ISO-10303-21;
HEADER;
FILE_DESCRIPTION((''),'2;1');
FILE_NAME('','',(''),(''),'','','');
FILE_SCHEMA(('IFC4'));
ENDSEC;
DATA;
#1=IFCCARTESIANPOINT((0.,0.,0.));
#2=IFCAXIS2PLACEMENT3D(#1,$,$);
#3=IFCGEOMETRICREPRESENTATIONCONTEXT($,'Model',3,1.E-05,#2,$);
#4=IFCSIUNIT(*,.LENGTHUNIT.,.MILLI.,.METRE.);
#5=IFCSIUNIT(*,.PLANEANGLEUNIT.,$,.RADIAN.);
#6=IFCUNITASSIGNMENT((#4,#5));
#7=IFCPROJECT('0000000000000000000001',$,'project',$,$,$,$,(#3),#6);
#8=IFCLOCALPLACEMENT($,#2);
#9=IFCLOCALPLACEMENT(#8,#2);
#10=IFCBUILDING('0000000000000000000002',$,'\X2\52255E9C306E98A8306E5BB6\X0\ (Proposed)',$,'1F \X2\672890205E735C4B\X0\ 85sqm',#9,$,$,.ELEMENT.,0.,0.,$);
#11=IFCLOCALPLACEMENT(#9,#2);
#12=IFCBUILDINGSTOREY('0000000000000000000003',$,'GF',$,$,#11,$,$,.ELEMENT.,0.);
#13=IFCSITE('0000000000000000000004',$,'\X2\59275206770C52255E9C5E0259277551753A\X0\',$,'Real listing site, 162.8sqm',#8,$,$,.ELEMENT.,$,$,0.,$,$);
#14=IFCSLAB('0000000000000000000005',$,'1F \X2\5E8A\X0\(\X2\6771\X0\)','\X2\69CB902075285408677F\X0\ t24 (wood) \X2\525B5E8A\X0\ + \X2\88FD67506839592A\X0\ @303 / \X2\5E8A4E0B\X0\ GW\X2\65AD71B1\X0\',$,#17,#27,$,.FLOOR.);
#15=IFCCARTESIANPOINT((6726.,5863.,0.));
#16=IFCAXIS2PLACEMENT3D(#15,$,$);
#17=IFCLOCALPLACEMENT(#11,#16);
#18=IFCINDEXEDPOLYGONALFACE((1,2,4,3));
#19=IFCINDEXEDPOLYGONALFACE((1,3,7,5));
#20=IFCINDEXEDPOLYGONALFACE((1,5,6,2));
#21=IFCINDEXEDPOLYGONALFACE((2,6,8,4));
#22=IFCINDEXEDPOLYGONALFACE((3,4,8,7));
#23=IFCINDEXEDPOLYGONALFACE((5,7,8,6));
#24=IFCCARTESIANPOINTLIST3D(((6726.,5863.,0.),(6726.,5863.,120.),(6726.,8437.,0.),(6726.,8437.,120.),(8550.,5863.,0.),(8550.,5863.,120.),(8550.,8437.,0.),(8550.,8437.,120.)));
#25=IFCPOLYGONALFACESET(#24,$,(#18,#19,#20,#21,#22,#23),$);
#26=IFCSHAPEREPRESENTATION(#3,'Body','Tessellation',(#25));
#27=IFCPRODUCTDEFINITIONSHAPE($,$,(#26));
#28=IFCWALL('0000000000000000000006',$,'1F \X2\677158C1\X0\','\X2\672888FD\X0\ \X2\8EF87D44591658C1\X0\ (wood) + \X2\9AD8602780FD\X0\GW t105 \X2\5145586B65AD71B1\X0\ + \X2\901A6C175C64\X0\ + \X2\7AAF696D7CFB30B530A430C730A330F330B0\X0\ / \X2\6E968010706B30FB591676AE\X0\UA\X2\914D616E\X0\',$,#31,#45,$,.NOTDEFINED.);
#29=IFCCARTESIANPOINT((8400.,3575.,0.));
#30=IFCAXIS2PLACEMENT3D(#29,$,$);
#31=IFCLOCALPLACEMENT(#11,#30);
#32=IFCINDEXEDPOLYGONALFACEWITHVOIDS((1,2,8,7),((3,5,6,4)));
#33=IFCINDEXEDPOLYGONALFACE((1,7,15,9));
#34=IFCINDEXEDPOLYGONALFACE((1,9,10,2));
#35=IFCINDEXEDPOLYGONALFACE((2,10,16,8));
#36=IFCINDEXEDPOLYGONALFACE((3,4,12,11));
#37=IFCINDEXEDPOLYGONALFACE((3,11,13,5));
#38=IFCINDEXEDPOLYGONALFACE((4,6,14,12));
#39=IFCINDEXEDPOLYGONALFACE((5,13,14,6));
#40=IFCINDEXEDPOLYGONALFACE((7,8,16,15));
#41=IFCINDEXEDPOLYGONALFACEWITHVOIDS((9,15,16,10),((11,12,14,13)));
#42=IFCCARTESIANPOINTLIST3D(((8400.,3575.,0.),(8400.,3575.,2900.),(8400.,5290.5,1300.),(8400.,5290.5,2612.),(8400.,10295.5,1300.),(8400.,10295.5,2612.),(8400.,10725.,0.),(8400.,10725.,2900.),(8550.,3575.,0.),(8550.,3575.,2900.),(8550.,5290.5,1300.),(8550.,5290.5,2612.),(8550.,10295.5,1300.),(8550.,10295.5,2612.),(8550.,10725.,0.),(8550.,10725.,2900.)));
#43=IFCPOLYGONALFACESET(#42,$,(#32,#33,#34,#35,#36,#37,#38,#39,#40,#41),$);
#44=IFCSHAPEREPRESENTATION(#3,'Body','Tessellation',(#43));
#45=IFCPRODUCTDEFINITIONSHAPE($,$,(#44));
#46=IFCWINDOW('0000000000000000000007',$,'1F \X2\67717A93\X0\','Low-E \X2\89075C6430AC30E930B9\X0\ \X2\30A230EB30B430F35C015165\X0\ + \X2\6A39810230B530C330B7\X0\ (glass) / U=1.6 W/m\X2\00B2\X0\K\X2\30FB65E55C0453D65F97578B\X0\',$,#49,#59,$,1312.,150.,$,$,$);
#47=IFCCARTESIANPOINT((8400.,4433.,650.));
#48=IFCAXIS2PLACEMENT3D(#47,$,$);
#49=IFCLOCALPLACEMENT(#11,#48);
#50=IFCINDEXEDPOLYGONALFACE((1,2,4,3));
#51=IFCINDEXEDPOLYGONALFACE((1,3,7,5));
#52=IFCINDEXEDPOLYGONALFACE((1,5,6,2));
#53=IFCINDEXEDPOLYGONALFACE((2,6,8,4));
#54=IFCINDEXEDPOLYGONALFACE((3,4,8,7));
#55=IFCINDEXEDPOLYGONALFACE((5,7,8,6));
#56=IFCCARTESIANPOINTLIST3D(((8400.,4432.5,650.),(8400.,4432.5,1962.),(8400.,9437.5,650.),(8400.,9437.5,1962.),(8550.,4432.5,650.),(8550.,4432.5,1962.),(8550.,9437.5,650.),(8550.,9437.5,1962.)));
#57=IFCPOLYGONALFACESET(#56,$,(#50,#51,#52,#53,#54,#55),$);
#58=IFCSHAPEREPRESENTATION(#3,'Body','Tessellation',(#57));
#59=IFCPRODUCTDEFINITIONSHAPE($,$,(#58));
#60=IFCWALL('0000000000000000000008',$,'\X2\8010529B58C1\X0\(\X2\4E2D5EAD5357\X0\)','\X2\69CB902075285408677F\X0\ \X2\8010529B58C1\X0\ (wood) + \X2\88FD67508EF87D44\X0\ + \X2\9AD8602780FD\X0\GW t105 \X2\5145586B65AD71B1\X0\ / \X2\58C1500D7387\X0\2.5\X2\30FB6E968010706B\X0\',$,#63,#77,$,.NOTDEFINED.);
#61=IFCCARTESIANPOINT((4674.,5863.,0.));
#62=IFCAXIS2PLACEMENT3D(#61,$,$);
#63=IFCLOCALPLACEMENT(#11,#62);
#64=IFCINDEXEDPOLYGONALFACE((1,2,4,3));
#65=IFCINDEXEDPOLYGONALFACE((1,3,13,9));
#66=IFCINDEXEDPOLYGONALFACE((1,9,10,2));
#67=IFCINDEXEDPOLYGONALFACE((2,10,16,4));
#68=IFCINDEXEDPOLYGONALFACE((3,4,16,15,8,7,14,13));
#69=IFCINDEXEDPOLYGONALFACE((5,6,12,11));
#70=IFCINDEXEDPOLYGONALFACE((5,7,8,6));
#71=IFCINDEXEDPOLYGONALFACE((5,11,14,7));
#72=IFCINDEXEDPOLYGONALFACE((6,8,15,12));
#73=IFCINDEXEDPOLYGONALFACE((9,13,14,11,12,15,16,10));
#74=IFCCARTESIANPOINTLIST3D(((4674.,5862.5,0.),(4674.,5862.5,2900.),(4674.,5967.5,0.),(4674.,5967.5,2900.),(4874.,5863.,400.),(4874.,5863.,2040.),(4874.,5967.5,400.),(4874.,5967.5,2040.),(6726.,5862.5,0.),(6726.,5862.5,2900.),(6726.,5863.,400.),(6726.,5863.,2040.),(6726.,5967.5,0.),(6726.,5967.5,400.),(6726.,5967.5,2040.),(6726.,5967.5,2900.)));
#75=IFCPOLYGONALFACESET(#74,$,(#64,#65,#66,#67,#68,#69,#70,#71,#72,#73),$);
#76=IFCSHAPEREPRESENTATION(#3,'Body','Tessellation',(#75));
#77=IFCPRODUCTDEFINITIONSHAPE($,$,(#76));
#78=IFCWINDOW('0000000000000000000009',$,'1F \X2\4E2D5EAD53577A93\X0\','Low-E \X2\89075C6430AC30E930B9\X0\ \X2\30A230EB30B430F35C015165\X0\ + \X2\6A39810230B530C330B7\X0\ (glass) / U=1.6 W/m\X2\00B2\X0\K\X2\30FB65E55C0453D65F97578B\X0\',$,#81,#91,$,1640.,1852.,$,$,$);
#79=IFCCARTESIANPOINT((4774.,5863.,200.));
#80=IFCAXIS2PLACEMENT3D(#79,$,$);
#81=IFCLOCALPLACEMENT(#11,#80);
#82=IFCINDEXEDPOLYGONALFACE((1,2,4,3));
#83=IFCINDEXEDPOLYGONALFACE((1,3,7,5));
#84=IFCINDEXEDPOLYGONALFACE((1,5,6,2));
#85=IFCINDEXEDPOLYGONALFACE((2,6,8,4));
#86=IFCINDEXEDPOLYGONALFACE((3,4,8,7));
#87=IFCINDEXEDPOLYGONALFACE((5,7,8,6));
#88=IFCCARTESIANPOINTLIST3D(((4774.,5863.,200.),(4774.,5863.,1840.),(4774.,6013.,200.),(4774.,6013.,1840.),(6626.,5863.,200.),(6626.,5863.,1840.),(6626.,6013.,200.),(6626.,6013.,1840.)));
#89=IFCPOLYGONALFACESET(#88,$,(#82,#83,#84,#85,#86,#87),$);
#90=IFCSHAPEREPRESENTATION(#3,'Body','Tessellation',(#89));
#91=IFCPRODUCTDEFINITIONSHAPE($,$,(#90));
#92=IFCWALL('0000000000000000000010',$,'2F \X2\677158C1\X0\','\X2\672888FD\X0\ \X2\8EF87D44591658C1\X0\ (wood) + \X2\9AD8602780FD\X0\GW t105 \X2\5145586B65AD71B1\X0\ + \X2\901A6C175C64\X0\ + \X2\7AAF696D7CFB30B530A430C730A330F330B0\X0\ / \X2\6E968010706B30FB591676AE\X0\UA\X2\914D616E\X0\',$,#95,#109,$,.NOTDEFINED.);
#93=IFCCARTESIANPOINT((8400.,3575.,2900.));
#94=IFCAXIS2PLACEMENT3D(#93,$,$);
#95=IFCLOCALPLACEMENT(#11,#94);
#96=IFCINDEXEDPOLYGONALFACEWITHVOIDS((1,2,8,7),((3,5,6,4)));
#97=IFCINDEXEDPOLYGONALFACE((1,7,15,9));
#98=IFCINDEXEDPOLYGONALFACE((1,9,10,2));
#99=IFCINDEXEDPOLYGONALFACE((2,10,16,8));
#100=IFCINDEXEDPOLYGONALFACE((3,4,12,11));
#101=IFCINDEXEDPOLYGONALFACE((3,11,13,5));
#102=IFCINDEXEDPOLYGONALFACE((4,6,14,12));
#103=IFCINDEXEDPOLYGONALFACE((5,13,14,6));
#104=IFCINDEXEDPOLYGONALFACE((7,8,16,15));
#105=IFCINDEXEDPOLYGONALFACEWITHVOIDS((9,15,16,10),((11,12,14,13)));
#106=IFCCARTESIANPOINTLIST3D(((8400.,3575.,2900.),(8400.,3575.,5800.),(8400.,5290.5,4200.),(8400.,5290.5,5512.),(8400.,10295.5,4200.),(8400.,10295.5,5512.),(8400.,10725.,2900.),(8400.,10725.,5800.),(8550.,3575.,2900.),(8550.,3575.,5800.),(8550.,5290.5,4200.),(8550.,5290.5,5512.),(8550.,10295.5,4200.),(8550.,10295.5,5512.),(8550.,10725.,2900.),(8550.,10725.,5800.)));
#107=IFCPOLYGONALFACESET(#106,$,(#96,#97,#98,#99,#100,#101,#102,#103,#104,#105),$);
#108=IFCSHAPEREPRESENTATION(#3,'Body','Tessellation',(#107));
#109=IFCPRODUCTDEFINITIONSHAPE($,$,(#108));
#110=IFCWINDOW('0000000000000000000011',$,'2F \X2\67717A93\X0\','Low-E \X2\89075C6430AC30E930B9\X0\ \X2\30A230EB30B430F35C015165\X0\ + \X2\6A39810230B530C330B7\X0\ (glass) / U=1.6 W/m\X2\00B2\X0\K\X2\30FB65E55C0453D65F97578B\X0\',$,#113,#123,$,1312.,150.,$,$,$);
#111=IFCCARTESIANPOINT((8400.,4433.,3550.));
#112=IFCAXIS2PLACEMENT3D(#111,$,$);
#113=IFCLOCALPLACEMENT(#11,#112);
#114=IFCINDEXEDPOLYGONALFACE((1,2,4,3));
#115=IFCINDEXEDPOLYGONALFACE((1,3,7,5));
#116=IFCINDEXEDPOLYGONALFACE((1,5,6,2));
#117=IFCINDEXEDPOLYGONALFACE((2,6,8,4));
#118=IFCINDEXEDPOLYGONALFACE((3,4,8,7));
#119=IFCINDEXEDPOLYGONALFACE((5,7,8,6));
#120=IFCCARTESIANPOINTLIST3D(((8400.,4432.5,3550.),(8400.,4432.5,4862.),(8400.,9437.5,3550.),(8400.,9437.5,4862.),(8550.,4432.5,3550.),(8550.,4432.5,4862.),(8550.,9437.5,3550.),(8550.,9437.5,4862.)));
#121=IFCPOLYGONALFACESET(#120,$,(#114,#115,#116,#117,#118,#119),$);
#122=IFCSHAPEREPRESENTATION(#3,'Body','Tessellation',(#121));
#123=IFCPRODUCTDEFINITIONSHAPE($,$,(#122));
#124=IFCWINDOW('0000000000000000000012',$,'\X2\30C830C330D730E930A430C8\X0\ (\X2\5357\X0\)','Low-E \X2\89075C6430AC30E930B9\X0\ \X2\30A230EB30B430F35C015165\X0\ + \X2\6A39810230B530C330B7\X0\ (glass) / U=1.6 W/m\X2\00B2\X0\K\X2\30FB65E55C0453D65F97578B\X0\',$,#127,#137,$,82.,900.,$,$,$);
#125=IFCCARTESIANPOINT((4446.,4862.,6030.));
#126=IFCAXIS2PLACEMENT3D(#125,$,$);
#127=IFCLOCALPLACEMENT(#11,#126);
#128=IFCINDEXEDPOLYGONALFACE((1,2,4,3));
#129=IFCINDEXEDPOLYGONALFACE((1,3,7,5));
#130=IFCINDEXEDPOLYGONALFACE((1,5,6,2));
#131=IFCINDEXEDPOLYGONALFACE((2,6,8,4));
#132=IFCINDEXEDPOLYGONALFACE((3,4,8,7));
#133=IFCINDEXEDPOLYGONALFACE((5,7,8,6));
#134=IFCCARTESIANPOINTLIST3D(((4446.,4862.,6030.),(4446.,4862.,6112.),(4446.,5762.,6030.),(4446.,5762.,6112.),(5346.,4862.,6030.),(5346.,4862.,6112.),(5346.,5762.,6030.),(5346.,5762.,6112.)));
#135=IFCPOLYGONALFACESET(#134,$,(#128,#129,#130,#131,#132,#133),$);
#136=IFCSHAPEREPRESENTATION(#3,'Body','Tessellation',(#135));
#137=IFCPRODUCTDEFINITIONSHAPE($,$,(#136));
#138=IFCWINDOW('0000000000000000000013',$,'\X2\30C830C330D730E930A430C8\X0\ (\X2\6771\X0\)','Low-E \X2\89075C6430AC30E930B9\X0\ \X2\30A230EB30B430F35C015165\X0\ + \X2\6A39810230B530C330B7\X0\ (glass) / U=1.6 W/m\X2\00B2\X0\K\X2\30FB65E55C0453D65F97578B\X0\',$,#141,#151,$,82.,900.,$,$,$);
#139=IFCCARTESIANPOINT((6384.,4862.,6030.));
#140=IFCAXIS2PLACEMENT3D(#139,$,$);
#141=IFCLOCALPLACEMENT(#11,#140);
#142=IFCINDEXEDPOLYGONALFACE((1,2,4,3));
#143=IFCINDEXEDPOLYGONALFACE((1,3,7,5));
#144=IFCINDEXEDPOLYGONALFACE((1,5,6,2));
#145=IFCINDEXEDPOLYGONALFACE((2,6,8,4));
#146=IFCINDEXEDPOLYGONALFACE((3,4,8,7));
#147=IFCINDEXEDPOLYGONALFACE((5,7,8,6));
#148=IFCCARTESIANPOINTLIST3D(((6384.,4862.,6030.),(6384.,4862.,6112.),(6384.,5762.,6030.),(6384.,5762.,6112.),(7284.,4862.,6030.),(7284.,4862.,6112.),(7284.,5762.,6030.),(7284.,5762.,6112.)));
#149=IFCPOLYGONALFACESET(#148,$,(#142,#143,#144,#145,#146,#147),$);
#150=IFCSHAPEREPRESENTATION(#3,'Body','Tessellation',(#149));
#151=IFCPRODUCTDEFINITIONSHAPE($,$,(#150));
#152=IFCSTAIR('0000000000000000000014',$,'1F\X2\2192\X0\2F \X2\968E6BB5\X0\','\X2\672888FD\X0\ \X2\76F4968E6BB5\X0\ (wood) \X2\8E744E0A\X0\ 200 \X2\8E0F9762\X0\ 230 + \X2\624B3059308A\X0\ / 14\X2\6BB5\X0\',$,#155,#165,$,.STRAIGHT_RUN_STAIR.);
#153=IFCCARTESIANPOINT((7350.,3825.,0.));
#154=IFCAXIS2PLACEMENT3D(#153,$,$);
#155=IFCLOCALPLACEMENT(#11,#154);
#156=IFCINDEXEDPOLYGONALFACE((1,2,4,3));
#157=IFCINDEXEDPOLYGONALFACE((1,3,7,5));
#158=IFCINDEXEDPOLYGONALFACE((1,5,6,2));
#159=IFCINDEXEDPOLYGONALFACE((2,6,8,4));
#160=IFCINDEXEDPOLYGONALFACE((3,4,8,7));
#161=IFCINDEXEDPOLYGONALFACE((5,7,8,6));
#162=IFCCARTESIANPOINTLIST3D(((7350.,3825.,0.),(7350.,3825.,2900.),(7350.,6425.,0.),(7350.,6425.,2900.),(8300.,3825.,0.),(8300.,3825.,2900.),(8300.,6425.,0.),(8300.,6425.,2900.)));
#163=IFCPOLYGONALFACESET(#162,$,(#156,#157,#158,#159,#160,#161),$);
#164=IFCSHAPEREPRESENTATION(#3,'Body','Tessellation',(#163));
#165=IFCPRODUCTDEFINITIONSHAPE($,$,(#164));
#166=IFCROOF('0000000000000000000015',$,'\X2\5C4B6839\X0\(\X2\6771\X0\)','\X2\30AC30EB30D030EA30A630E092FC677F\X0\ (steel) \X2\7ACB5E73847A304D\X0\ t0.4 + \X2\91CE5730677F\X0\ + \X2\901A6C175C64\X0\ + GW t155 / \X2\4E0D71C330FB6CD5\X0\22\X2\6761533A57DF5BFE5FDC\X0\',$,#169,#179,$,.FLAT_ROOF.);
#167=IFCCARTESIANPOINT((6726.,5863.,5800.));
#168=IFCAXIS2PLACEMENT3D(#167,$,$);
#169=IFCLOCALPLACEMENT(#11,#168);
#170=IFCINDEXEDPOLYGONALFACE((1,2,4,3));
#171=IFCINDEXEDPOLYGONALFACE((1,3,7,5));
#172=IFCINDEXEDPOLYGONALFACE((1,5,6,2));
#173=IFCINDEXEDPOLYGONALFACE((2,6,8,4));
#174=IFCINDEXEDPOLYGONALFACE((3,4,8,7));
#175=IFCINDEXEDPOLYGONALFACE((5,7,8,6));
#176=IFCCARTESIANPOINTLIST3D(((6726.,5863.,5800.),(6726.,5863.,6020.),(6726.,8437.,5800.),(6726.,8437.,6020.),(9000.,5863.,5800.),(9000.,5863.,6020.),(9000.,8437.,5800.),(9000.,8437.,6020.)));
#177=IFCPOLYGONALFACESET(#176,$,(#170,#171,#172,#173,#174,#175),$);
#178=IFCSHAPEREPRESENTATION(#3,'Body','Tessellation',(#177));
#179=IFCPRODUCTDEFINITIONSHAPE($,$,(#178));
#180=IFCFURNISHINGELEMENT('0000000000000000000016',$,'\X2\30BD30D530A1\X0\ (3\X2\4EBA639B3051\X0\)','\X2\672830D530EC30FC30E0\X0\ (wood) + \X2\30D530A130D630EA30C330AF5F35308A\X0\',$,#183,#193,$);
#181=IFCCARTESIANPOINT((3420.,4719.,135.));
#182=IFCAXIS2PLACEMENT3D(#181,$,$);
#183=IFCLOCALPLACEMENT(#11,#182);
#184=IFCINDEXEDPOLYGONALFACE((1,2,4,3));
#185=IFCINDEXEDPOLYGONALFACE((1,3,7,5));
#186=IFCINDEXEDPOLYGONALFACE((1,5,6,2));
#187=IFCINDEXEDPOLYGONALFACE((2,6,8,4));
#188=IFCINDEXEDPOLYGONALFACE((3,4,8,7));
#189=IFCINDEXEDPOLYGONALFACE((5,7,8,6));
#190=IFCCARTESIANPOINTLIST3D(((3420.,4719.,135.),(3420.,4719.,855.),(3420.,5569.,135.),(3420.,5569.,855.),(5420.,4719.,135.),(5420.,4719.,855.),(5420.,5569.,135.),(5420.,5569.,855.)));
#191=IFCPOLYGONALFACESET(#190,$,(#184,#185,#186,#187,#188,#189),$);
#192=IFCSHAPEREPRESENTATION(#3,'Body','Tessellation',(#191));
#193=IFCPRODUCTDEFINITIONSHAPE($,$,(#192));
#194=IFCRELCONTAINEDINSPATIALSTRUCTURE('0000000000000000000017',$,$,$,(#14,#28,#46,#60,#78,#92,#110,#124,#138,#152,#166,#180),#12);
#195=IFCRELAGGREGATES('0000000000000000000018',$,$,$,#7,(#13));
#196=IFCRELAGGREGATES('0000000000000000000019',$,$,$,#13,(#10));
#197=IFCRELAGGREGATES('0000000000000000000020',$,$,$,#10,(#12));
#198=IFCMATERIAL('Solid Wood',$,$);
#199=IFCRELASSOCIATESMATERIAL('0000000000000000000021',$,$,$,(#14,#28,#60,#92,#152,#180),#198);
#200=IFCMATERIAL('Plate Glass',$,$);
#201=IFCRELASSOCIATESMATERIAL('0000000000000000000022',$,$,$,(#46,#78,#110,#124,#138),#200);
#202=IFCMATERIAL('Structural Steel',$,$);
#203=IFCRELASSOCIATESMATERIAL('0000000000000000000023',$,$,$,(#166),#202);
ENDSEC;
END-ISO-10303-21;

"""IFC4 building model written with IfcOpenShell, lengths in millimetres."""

from ifc_helpers import new_model, si_unit, frame, frame_2d, origin, place, context, project, spatial, rectangle, extrude, material, element, fill, save


model = new_model("IFC4")

# Units and contexts
model_context = context("Model", 3, precision=1e-05, world=origin())
ifc_project = project(units=[si_unit("LENGTHUNIT", "METRE", prefix="MILLI"), si_unit("PLANEANGLEUNIT", "RADIAN")], contexts=[model_context])

# Site, building, storey
site_placement = place(None, origin())
site = spatial("IfcSite", under=ifc_project, at=site_placement, Name="大分県別府市大畑町", ObjectType="Real listing site, 162.8sqm", CompositionType="ELEMENT", RefElevation=0.0)
building_placement = place(site_placement, origin())
building = spatial("IfcBuilding", under=site, at=building_placement, Name="別府の風の家 (Proposed)", ObjectType="1F 木造平屋 85sqm", CompositionType="ELEMENT", ElevationOfRefHeight=0.0, ElevationOfTerrain=0.0)
storey_placement = place(building_placement, origin())
storey = spatial("IfcBuildingStorey", under=building, at=storey_placement, Name="GF", CompositionType="ELEMENT", Elevation=0.0)

# Slab
ifc_material_1 = material(Name="Solid Wood")
slab_placement = place(storey_placement, frame((6726.0, 5863.0, 0.0)))
element("IfcSlab", 1, at=slab_placement, inside=storey, material=ifc_material_1, Name="1F 床(東)", Description="構造用合板 t24 (wood) 剛床 + 製材根太 @303 / 床下 GW断熱", PredefinedType="FLOOR", context=model_context, shape_type="SweptSolid", body=[
    extrude(rectangle(XDim=1824.0, YDim=2574.0, at=frame_2d((912.0, 1287.0))), frame((6726.0, 5863.0, 0.0)), (0.0, 0.0, 1.0), 120.0),
])

# Walls, openings, windows
wall_1_placement = place(storey_placement, frame((8400.0, 3575.0, 0.0)))
wall_1 = element("IfcWall", 2, at=wall_1_placement, inside=storey, material=ifc_material_1, Name="1F 東壁", Description="木製 軸組外壁 (wood) + 高性能GW t105 充填断熱 + 通気層 + 窯業系サイディング / 準耐火・外皮UA配慮", PredefinedType="NOTDEFINED", context=model_context, shape_type="SweptSolid", body=[
    extrude(rectangle(XDim=150.0, YDim=7150.0, at=frame_2d((75.0, 3575.0))), frame((8400.0, 3575.0, 0.0)), (0.0, 0.0, 1.0), 2900.0),
])
opening_1_placement = place(storey_placement, frame((8400.0, 4433.0, 650.0)))
opening_1 = element("IfcOpeningElement", 3, at=opening_1_placement, cuts=wall_1, PredefinedType="NOTDEFINED", context=model_context, shape_type="SweptSolid", body=[
    extrude(rectangle(XDim=150.0, YDim=5005.0, at=frame_2d((75.0, 2502.0))), frame((8400.0, 4433.0, 650.0)), (0.0, 0.0, 1.0), 1312.0),
])
ifc_material_2 = material(Name="Plate Glass")
window_1_placement = place(storey_placement, frame((8400.0, 4433.0, 650.0)))
window_1 = element("IfcWindow", 4, at=window_1_placement, inside=storey, material=ifc_material_2, Name="1F 東窓", Description="Low-E 複層ガラス アルゴン封入 + 樹脂サッシ (glass) / U=1.6 W/m²K・日射取得型", OverallHeight=1312.0, OverallWidth=150.0, context=model_context, shape_type="SweptSolid", body=[
    extrude(rectangle(XDim=150.0, YDim=5005.0, at=frame_2d((75.0, 2502.0))), frame((8400.0, 4433.0, 650.0)), (0.0, 0.0, 1.0), 1312.0),
])
fill(opening_1, window_1)
wall_2_placement = place(storey_placement, frame((4674.0, 5863.0, 0.0)))
wall_2 = element("IfcWall", 5, at=wall_2_placement, inside=storey, material=ifc_material_1, Name="耐力壁(中庭南)", Description="構造用合板 耐力壁 (wood) + 製材軸組 + 高性能GW t105 充填断熱 / 壁倍率2.5・準耐火", PredefinedType="NOTDEFINED", context=model_context, shape_type="SweptSolid", body=[
    extrude(rectangle(XDim=2052.0, YDim=105.0, at=frame_2d((1026.0, 52.0))), frame((4674.0, 5863.0, 0.0)), (0.0, 0.0, 1.0), 2900.0),
])
opening_2_placement = place(storey_placement, frame((4774.0, 5863.0, 200.0)))
opening_2 = element("IfcOpeningElement", 6, at=opening_2_placement, cuts=wall_2, PredefinedType="NOTDEFINED", context=model_context, shape_type="SweptSolid", body=[
    extrude(rectangle(XDim=1852.0, YDim=150.0, at=frame_2d((926.0, 75.0))), frame((4774.0, 5863.0, 200.0)), (0.0, 0.0, 1.0), 1640.0),
])
window_2_placement = place(storey_placement, frame((4774.0, 5863.0, 200.0)))
window_2 = element("IfcWindow", 7, at=window_2_placement, inside=storey, material=ifc_material_2, Name="1F 中庭南窓", Description="Low-E 複層ガラス アルゴン封入 + 樹脂サッシ (glass) / U=1.6 W/m²K・日射取得型", OverallHeight=1640.0, OverallWidth=1852.0, context=model_context, shape_type="SweptSolid", body=[
    extrude(rectangle(XDim=1852.0, YDim=150.0, at=frame_2d((926.0, 75.0))), frame((4774.0, 5863.0, 200.0)), (0.0, 0.0, 1.0), 1640.0),
])
fill(opening_2, window_2)

# Wall, opening, window
wall_3_placement = place(storey_placement, frame((8400.0, 3575.0, 2900.0)))
wall_3 = element("IfcWall", 8, at=wall_3_placement, inside=storey, material=ifc_material_1, Name="2F 東壁", Description="木製 軸組外壁 (wood) + 高性能GW t105 充填断熱 + 通気層 + 窯業系サイディング / 準耐火・外皮UA配慮", PredefinedType="NOTDEFINED", context=model_context, shape_type="SweptSolid", body=[
    extrude(rectangle(XDim=150.0, YDim=7150.0, at=frame_2d((75.0, 3575.0))), frame((8400.0, 3575.0, 2900.0)), (0.0, 0.0, 1.0), 2900.0),
])
opening_3_placement = place(storey_placement, frame((8400.0, 4433.0, 3550.0)))
opening_3 = element("IfcOpeningElement", 9, at=opening_3_placement, cuts=wall_3, PredefinedType="NOTDEFINED", context=model_context, shape_type="SweptSolid", body=[
    extrude(rectangle(XDim=150.0, YDim=5005.0, at=frame_2d((75.0, 2502.0))), frame((8400.0, 4433.0, 3550.0)), (0.0, 0.0, 1.0), 1312.0),
])
window_3_placement = place(storey_placement, frame((8400.0, 4433.0, 3550.0)))
window_3 = element("IfcWindow", 10, at=window_3_placement, inside=storey, material=ifc_material_2, Name="2F 東窓", Description="Low-E 複層ガラス アルゴン封入 + 樹脂サッシ (glass) / U=1.6 W/m²K・日射取得型", OverallHeight=1312.0, OverallWidth=150.0, context=model_context, shape_type="SweptSolid", body=[
    extrude(rectangle(XDim=150.0, YDim=5005.0, at=frame_2d((75.0, 2502.0))), frame((8400.0, 4433.0, 3550.0)), (0.0, 0.0, 1.0), 1312.0),
])
fill(opening_3, window_3)

# Windows
window_4_placement = place(storey_placement, frame((4446.0, 4862.0, 6030.0)))
element("IfcWindow", 11, at=window_4_placement, inside=storey, material=ifc_material_2, Name="トップライト (南)", Description="Low-E 複層ガラス アルゴン封入 + 樹脂サッシ (glass) / U=1.6 W/m²K・日射取得型", OverallHeight=82.0, OverallWidth=900.0, context=model_context, shape_type="SweptSolid", body=[
    extrude(rectangle(XDim=900.0, YDim=900.0, at=frame_2d((450.0, 450.0))), frame((4446.0, 4862.0, 6030.0)), (0.0, 0.0, 1.0), 82.0),
])
window_5_placement = place(storey_placement, frame((6384.0, 4862.0, 6030.0)))
element("IfcWindow", 12, at=window_5_placement, inside=storey, material=ifc_material_2, Name="トップライト (東)", Description="Low-E 複層ガラス アルゴン封入 + 樹脂サッシ (glass) / U=1.6 W/m²K・日射取得型", OverallHeight=82.0, OverallWidth=900.0, context=model_context, shape_type="SweptSolid", body=[
    extrude(rectangle(XDim=900.0, YDim=900.0, at=frame_2d((450.0, 450.0))), frame((6384.0, 4862.0, 6030.0)), (0.0, 0.0, 1.0), 82.0),
])

# Stair
stair_placement = place(storey_placement, frame((7350.0, 3825.0, 0.0)))
element("IfcStair", 13, at=stair_placement, inside=storey, material=ifc_material_1, Name="1F→2F 階段", Description="木製 直階段 (wood) 蹴上 200 踏面 230 + 手すり / 14段", PredefinedType="STRAIGHT_RUN_STAIR", context=model_context, shape_type="SweptSolid", body=[
    extrude(rectangle(XDim=950.0, YDim=2600.0, at=frame_2d((475.0, 1300.0))), frame((7350.0, 3825.0, 0.0)), (0.0, 0.0, 1.0), 2900.0),
])

# Roof
ifc_material_3 = material(Name="Structural Steel")
roof_placement = place(storey_placement, frame((6726.0, 5863.0, 5800.0)))
element("IfcRoof", 14, at=roof_placement, inside=storey, material=ifc_material_3, Name="屋根(東)", Description="ガルバリウム鋼板 (steel) 立平葺き t0.4 + 野地板 + 通気層 + GW t155 / 不燃・法22条区域対応", PredefinedType="FLAT_ROOF", context=model_context, shape_type="SweptSolid", body=[
    extrude(rectangle(XDim=2274.0, YDim=2574.0, at=frame_2d((1137.0, 1287.0))), frame((6726.0, 5863.0, 5800.0)), (0.0, 0.0, 1.0), 220.0),
])

# Furnishing element
furnishing_1_placement = place(storey_placement, frame((3420.0, 4719.0, 135.0)))
element("IfcFurnishingElement", 15, at=furnishing_1_placement, inside=storey, material=ifc_material_1, Name="ソファ (3人掛け)", Description="木フレーム (wood) + ファブリック張り", context=model_context, shape_type="SweptSolid", body=[
    extrude(rectangle(XDim=2000.0, YDim=850.0, at=frame_2d((1000.0, 425.0))), frame((3420.0, 4719.0, 135.0)), (0.0, 0.0, 1.0), 720.0),
])

save(model, "model.ifc")
